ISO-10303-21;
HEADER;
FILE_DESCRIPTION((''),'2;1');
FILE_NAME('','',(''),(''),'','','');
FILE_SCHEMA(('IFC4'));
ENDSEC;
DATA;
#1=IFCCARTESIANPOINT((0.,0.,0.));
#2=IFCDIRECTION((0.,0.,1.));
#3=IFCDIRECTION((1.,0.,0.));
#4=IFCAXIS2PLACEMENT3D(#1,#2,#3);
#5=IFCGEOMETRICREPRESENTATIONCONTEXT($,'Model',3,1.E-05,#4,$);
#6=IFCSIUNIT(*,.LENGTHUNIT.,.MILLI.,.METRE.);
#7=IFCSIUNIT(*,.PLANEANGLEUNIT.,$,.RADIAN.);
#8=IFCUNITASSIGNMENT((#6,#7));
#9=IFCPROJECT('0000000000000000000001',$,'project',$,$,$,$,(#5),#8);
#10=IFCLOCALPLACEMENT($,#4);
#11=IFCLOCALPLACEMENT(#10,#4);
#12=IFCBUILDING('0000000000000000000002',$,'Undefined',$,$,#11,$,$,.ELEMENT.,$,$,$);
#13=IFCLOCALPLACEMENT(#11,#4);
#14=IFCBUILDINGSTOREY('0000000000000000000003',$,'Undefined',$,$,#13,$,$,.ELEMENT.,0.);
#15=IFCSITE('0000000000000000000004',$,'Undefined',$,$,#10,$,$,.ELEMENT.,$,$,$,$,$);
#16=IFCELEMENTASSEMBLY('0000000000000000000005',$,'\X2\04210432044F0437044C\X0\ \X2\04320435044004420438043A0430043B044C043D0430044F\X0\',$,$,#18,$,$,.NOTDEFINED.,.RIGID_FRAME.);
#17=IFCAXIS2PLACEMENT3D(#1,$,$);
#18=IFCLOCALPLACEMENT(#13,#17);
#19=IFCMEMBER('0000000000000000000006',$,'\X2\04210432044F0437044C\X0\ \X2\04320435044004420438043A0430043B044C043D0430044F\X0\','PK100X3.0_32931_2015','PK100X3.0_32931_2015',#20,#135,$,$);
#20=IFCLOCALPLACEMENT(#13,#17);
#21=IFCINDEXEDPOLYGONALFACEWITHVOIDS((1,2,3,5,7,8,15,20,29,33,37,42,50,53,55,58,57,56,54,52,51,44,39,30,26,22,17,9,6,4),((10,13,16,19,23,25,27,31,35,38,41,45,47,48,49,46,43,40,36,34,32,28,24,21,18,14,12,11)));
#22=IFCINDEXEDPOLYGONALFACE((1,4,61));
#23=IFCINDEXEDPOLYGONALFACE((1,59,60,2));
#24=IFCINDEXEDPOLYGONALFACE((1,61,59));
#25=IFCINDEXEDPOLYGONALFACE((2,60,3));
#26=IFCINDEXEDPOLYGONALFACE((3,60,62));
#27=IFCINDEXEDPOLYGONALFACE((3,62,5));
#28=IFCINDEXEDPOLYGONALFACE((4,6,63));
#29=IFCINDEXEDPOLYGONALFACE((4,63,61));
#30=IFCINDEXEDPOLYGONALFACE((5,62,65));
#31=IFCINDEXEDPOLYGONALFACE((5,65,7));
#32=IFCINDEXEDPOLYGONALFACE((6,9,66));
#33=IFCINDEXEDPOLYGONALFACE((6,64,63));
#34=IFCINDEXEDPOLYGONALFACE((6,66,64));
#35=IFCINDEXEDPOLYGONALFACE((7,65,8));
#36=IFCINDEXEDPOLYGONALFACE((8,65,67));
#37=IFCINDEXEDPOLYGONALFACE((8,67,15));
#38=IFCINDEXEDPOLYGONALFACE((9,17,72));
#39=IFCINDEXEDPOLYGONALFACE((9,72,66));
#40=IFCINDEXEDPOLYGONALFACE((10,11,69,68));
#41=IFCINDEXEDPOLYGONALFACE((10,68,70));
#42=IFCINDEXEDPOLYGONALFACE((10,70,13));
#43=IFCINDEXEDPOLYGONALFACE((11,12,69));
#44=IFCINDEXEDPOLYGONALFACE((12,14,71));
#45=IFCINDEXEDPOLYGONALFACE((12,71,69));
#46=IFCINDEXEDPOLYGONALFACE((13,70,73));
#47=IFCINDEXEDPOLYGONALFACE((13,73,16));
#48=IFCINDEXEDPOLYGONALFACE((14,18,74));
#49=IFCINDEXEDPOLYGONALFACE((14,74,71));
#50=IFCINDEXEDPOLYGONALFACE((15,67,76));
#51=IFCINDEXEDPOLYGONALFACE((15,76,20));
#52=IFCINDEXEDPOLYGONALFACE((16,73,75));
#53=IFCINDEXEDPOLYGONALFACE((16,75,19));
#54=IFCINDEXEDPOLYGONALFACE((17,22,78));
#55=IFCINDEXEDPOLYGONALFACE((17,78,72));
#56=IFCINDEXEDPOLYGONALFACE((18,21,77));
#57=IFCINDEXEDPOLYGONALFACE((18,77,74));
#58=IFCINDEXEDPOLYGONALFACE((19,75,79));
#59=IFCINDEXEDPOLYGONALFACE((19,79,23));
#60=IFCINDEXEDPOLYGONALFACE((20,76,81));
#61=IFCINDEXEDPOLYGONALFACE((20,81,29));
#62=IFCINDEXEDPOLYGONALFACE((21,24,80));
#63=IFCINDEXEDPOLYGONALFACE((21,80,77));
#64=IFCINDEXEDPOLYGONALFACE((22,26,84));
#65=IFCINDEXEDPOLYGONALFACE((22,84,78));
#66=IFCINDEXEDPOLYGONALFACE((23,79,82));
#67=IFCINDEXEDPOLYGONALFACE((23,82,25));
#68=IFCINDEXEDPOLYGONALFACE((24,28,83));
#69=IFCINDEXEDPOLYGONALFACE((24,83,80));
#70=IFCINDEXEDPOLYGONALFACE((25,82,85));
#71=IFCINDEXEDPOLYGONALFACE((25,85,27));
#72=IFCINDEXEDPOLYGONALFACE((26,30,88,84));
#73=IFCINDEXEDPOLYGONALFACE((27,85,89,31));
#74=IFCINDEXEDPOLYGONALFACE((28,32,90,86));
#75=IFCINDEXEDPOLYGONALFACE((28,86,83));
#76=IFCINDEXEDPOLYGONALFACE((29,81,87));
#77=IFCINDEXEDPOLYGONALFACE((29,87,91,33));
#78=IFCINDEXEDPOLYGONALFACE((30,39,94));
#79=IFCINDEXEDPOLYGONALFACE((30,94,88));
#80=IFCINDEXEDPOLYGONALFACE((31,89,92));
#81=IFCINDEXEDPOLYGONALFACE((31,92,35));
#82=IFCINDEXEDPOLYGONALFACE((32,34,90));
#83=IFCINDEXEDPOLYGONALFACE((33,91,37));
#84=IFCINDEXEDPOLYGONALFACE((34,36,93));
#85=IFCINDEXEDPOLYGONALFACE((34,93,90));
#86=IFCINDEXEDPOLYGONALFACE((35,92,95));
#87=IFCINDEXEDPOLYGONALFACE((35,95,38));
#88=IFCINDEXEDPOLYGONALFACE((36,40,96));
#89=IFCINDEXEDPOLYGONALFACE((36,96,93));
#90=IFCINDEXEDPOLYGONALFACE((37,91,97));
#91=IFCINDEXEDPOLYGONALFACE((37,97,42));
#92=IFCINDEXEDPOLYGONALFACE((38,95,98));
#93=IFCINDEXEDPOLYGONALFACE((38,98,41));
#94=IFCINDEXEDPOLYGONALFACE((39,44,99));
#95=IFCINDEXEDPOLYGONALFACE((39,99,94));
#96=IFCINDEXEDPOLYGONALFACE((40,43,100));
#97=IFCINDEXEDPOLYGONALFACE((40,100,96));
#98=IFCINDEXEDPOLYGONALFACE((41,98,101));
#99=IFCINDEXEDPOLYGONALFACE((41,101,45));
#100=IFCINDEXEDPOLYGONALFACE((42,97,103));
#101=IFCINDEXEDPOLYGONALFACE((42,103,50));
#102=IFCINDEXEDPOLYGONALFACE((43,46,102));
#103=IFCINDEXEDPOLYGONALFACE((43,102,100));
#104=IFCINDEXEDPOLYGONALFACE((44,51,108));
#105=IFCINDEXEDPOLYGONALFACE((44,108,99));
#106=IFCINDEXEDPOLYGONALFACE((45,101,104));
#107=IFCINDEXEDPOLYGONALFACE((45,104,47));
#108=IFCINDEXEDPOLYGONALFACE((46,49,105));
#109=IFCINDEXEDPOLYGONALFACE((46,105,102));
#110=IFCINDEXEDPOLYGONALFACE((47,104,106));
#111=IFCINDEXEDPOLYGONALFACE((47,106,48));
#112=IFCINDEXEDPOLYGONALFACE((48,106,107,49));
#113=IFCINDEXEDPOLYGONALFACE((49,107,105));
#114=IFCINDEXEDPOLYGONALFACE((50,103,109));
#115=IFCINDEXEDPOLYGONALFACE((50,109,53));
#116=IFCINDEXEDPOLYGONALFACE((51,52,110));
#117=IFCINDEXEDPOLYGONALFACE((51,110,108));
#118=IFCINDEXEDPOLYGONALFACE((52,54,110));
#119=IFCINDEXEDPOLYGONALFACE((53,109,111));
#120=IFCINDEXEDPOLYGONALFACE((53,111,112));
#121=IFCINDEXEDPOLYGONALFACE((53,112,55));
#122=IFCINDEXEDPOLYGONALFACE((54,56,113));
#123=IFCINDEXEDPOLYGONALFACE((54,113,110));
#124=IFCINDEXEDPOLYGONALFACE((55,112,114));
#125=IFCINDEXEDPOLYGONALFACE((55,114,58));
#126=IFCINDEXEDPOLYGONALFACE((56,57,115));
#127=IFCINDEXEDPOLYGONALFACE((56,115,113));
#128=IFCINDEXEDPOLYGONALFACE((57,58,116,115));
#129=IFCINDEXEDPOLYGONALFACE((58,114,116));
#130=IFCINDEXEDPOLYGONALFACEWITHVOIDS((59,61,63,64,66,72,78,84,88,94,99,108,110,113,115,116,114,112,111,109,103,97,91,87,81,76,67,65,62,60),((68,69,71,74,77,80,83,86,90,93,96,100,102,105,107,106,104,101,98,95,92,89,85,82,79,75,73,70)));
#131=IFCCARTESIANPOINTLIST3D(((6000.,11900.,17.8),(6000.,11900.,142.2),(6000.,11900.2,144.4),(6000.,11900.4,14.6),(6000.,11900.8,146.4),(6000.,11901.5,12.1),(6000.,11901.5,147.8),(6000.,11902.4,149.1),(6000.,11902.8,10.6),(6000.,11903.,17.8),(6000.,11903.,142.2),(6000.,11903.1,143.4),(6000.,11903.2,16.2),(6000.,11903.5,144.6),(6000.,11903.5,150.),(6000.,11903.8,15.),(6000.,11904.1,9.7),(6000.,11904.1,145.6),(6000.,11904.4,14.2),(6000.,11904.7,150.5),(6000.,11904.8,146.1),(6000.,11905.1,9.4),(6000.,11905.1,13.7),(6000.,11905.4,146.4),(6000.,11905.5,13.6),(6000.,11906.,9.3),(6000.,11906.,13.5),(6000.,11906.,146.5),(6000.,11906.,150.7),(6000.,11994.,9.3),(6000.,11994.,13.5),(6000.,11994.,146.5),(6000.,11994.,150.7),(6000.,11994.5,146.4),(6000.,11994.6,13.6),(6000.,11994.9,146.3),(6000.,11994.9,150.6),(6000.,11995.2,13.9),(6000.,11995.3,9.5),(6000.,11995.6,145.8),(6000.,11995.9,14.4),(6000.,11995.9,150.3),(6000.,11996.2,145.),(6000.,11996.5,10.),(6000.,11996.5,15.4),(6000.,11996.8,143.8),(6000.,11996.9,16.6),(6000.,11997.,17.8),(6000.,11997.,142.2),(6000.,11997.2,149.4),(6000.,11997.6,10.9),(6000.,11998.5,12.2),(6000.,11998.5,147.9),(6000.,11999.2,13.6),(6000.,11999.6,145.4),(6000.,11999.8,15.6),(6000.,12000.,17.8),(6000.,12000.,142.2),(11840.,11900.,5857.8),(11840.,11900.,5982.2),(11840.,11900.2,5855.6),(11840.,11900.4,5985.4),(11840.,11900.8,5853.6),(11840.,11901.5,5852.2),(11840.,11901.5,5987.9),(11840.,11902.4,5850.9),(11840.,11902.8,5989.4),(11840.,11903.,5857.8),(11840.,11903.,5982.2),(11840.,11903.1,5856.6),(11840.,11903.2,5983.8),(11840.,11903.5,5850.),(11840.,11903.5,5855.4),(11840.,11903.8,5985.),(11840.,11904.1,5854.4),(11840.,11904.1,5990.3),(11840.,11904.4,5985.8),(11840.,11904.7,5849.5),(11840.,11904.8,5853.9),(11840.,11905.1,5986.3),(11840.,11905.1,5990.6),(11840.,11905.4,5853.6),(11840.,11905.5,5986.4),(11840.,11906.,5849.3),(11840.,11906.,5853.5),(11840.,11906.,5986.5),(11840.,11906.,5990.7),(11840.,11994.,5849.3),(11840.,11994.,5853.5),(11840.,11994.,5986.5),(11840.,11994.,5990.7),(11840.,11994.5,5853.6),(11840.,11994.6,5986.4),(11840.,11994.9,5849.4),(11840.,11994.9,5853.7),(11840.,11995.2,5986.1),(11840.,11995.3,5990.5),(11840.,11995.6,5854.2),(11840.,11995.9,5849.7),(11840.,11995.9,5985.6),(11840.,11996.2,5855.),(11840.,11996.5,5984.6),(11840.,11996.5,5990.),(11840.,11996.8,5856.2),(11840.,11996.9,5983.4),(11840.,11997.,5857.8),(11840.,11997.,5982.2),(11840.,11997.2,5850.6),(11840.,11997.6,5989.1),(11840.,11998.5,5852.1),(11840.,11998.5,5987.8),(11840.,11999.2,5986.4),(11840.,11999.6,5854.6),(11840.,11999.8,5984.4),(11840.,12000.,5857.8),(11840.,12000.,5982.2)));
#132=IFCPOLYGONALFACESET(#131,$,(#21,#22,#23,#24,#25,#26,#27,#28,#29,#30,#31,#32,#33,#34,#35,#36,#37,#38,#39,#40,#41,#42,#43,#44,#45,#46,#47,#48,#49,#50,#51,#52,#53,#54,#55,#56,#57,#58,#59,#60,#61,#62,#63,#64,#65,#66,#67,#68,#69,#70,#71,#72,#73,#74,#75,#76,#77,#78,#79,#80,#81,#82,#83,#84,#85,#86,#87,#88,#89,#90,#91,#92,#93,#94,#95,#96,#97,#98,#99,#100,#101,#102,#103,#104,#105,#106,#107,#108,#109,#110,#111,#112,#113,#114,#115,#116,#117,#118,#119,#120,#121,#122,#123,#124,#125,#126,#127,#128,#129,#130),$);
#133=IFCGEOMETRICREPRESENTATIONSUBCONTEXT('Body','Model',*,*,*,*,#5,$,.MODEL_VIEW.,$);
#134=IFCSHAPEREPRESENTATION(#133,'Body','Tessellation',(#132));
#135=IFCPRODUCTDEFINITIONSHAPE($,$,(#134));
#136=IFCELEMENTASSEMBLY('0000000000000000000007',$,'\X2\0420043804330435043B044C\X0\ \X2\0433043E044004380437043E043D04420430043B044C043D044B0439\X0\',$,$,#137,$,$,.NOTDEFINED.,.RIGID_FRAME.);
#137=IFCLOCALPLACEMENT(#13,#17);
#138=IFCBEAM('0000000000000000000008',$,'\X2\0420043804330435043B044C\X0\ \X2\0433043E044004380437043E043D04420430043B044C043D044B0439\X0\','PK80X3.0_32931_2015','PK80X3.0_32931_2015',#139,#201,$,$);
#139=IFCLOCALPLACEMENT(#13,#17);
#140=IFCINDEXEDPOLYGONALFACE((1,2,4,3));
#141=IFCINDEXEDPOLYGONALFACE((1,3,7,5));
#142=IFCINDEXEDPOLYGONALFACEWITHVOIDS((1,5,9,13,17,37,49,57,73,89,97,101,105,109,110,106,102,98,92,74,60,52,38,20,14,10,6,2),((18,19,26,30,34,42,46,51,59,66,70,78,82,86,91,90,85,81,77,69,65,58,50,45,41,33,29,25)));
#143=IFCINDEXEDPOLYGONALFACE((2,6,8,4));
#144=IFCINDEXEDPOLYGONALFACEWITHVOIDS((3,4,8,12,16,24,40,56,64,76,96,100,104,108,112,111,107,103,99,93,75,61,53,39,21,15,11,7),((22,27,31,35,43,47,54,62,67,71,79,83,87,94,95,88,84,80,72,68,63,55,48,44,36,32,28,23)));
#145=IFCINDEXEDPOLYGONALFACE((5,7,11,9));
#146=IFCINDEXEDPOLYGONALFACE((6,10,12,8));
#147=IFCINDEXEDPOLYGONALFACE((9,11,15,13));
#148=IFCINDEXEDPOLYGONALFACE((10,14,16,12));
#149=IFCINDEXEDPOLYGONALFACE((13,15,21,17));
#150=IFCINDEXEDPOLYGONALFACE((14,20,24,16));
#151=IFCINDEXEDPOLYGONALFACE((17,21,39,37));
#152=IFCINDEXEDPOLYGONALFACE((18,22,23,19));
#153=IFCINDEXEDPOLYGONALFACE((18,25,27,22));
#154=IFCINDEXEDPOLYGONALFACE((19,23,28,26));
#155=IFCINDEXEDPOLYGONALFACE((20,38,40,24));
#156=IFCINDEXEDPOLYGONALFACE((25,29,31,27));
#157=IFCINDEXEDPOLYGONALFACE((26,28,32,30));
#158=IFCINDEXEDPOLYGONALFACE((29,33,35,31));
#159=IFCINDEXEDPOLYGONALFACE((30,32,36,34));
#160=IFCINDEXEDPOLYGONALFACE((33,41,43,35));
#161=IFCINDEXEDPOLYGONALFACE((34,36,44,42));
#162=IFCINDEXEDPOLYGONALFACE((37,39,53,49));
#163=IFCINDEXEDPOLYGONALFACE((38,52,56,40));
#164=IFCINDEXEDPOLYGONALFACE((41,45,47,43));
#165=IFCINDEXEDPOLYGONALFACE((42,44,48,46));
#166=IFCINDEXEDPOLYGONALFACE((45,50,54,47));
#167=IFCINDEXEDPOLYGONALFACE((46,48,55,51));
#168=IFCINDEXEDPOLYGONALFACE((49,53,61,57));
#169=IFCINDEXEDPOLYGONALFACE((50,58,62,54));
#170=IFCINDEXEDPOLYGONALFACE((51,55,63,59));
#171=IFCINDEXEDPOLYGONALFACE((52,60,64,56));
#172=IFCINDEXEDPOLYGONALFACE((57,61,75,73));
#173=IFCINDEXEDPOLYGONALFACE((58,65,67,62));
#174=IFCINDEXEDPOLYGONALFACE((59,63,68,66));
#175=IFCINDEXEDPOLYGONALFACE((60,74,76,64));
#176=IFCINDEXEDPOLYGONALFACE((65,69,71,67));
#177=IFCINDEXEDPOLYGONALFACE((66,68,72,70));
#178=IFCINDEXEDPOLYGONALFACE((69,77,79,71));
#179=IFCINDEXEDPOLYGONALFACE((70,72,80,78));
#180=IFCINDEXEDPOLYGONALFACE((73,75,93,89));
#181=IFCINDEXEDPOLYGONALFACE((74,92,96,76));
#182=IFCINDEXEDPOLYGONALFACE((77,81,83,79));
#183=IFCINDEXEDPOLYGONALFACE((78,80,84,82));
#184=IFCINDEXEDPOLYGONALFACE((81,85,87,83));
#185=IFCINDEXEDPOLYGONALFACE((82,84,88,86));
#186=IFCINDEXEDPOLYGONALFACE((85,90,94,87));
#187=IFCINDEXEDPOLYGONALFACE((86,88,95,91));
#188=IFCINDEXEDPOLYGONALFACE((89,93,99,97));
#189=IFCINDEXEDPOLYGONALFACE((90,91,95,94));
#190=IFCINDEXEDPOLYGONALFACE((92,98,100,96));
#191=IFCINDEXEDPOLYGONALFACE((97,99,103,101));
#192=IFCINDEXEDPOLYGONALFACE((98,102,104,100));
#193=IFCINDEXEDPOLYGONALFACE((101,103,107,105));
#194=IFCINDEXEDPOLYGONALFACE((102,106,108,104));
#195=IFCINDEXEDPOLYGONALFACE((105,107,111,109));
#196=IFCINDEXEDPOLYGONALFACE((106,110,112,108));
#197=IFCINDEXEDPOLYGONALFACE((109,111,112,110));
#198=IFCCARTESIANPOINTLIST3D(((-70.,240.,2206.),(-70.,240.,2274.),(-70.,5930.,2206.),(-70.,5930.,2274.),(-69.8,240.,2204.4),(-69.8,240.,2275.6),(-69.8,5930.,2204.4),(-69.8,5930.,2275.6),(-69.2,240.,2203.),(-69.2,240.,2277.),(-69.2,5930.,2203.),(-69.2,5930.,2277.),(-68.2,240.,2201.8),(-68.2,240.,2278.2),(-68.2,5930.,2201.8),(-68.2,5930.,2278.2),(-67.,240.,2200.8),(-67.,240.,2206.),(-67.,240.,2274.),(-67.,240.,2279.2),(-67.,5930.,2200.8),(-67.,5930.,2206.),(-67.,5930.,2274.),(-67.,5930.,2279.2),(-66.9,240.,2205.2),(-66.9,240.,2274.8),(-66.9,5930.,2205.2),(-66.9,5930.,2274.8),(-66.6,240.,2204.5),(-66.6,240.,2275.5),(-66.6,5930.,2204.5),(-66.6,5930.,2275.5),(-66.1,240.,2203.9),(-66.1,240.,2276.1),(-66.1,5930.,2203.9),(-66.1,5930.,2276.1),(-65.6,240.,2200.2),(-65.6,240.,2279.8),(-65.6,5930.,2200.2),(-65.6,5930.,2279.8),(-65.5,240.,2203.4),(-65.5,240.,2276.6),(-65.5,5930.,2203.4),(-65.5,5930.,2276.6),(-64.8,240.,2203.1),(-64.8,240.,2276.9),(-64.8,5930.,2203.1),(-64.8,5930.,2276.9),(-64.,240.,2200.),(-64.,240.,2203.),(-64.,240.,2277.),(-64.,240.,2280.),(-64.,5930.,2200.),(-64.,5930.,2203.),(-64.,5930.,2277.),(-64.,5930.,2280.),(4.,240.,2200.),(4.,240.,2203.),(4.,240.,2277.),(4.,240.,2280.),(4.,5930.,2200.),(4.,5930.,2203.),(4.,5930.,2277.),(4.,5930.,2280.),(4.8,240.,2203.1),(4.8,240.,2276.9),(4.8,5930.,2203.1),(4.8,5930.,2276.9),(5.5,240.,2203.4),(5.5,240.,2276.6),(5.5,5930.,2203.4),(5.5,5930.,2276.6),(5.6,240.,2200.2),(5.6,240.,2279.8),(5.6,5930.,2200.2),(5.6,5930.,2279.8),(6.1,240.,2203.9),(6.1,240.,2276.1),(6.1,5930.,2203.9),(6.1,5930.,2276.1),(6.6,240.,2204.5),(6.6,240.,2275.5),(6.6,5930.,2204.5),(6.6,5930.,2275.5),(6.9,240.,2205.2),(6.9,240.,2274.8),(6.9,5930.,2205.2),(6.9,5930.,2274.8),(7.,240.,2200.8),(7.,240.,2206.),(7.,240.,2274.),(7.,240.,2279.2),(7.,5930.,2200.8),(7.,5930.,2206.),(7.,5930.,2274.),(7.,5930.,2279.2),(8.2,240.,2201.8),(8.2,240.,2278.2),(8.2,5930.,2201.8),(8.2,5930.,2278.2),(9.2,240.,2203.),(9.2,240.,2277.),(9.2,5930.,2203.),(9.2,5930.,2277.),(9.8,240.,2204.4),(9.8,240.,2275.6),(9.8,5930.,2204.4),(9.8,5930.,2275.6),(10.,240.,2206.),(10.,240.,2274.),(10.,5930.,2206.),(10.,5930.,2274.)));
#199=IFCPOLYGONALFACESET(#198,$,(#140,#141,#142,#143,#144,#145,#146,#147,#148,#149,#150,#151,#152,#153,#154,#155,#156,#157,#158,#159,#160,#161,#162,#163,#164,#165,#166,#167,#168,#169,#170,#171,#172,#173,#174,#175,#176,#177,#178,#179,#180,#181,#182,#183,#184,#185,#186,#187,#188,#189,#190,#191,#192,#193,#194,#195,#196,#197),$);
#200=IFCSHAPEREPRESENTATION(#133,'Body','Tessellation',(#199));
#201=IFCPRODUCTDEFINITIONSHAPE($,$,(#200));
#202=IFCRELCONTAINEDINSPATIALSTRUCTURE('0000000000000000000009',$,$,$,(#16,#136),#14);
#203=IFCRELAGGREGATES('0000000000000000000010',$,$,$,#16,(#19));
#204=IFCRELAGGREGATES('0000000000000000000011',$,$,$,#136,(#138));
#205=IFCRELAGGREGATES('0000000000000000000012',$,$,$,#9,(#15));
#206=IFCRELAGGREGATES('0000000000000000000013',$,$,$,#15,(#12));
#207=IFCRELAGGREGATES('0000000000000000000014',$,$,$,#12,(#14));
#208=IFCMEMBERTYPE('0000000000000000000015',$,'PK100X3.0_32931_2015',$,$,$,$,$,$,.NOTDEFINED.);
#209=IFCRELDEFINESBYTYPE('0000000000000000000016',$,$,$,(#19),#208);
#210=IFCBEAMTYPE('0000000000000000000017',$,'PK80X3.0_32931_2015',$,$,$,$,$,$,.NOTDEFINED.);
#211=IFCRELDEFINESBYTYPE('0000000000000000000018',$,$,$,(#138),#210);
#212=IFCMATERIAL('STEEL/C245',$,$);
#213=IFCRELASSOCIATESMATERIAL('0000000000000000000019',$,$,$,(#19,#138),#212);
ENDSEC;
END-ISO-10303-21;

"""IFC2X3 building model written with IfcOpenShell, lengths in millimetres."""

from ifc_helpers import new_model, si_unit, frame, origin_with_axes, origin_2d_with_axis, place, context, subcontext, project, spatial, hollow_rectangle, extrude, clip, halfspace, material, type_object, element, aggregate, save


model = new_model("IFC2X3")

# Units and contexts
model_context = context("Model", 3, precision=1e-05, world=origin_with_axes())
body_context = subcontext(model_context, "Body", "Model", "MODEL_VIEW")
ifc_project = project(units=[si_unit("LENGTHUNIT", "METRE", prefix="MILLI"), si_unit("PLANEANGLEUNIT", "RADIAN")], contexts=[model_context])

# Site, building, storey
site_placement = place(None, origin_with_axes())
site = spatial("IfcSite", under=ifc_project, at=site_placement, Name="Undefined", CompositionType="ELEMENT")
building_placement = place(site_placement, origin_with_axes())
building = spatial("IfcBuilding", under=site, at=building_placement, Name="Undefined", CompositionType="ELEMENT")
storey_placement = place(building_placement, origin_with_axes())
storey = spatial("IfcBuildingStorey", under=building, at=storey_placement, Name="Undefined", CompositionType="ELEMENT", Elevation=0.0)

# Shared definitions
ifc_material = material(Name="STEEL/C245")

# Element assembly, member
member_type_1 = type_object("IfcMemberType", Name="PK100X3.0_32931_2015", PredefinedType="NOTDEFINED")
assembly_1_placement = place(storey_placement, origin_with_axes())
assembly_1 = element("IfcElementAssembly", 1, at=assembly_1_placement, inside=storey, Name="Связь вертикальная", AssemblyPlace="NOTDEFINED", PredefinedType="RIGID_FRAME")
member_1_placement = place(assembly_1_placement, frame((5920.0, 11950.0, 0.0), z_axis=(-0.707107, 0.0, 0.707107), x_axis=(0.707107, 0.0, 0.707107)))
member_1 = element("IfcMember", 2, at=member_1_placement, type_object=member_type_1, material=ifc_material, Name="Связь вертикальная", Description="PK100X3.0_32931_2015", ObjectType="PK100X3.0_32931_2015", context=body_context, shape_type="Clipping", body=[
    clip(clip(extrude(hollow_rectangle(XDim=100.0, YDim=100.0, WallThickness=3.0, InnerFilletRadius=3.0, OuterFilletRadius=6.0, at=origin_2d_with_axis()), frame((8473.1, 0.0, 0.0), z_axis=(-1.0, 0.0, 0.0), x_axis=(0.0, -1.0, 0.0)), (0.0, 0.0, 1.0), 8461.0), halfspace(frame((8238.4, 50.0, -133.8), z_axis=(-0.707107, 0.0, 0.707107), x_axis=(-0.707107, 0.0, -0.707107)), True)), halfspace(frame((281.0, 50.0, 167.8), z_axis=(0.707107, 0.0, -0.707107), x_axis=(0.707107, 0.0, 0.707107)), True)),
])
aggregate(assembly_1, [member_1])

# Element assembly, beam
assembly_2_placement = place(storey_placement, origin_with_axes())
assembly_2 = element("IfcElementAssembly", 3, at=assembly_2_placement, inside=storey, Name="Ригель горизонтальный", AssemblyPlace="NOTDEFINED", PredefinedType="RIGID_FRAME")
beam_type_1 = type_object("IfcBeamType", Name="PK80X3.0_32931_2015", PredefinedType="NOTDEFINED")
beam_1_placement = place(assembly_2_placement, frame((-30.0, 5930.0, 2240.0), z_axis=(0.0, 0.0, 1.0), x_axis=(0.0, -1.0, 0.0)))
beam_1 = element("IfcBeam", 4, at=beam_1_placement, type_object=beam_type_1, material=ifc_material, Name="Ригель горизонтальный", Description="PK80X3.0_32931_2015", ObjectType="PK80X3.0_32931_2015", context=body_context, shape_type="SweptSolid", body=[
    extrude(hollow_rectangle(XDim=80.0, YDim=80.0, WallThickness=3.0, InnerFilletRadius=3.0, OuterFilletRadius=6.0, at=origin_2d_with_axis()), frame((5690.0, 0.0, 0.0), z_axis=(-1.0, 0.0, 0.0), x_axis=(0.0, -1.0, 0.0)), (0.0, 0.0, 1.0), 5690.0),
])
aggregate(assembly_2, [beam_1])

save(model, "model.ifc")
